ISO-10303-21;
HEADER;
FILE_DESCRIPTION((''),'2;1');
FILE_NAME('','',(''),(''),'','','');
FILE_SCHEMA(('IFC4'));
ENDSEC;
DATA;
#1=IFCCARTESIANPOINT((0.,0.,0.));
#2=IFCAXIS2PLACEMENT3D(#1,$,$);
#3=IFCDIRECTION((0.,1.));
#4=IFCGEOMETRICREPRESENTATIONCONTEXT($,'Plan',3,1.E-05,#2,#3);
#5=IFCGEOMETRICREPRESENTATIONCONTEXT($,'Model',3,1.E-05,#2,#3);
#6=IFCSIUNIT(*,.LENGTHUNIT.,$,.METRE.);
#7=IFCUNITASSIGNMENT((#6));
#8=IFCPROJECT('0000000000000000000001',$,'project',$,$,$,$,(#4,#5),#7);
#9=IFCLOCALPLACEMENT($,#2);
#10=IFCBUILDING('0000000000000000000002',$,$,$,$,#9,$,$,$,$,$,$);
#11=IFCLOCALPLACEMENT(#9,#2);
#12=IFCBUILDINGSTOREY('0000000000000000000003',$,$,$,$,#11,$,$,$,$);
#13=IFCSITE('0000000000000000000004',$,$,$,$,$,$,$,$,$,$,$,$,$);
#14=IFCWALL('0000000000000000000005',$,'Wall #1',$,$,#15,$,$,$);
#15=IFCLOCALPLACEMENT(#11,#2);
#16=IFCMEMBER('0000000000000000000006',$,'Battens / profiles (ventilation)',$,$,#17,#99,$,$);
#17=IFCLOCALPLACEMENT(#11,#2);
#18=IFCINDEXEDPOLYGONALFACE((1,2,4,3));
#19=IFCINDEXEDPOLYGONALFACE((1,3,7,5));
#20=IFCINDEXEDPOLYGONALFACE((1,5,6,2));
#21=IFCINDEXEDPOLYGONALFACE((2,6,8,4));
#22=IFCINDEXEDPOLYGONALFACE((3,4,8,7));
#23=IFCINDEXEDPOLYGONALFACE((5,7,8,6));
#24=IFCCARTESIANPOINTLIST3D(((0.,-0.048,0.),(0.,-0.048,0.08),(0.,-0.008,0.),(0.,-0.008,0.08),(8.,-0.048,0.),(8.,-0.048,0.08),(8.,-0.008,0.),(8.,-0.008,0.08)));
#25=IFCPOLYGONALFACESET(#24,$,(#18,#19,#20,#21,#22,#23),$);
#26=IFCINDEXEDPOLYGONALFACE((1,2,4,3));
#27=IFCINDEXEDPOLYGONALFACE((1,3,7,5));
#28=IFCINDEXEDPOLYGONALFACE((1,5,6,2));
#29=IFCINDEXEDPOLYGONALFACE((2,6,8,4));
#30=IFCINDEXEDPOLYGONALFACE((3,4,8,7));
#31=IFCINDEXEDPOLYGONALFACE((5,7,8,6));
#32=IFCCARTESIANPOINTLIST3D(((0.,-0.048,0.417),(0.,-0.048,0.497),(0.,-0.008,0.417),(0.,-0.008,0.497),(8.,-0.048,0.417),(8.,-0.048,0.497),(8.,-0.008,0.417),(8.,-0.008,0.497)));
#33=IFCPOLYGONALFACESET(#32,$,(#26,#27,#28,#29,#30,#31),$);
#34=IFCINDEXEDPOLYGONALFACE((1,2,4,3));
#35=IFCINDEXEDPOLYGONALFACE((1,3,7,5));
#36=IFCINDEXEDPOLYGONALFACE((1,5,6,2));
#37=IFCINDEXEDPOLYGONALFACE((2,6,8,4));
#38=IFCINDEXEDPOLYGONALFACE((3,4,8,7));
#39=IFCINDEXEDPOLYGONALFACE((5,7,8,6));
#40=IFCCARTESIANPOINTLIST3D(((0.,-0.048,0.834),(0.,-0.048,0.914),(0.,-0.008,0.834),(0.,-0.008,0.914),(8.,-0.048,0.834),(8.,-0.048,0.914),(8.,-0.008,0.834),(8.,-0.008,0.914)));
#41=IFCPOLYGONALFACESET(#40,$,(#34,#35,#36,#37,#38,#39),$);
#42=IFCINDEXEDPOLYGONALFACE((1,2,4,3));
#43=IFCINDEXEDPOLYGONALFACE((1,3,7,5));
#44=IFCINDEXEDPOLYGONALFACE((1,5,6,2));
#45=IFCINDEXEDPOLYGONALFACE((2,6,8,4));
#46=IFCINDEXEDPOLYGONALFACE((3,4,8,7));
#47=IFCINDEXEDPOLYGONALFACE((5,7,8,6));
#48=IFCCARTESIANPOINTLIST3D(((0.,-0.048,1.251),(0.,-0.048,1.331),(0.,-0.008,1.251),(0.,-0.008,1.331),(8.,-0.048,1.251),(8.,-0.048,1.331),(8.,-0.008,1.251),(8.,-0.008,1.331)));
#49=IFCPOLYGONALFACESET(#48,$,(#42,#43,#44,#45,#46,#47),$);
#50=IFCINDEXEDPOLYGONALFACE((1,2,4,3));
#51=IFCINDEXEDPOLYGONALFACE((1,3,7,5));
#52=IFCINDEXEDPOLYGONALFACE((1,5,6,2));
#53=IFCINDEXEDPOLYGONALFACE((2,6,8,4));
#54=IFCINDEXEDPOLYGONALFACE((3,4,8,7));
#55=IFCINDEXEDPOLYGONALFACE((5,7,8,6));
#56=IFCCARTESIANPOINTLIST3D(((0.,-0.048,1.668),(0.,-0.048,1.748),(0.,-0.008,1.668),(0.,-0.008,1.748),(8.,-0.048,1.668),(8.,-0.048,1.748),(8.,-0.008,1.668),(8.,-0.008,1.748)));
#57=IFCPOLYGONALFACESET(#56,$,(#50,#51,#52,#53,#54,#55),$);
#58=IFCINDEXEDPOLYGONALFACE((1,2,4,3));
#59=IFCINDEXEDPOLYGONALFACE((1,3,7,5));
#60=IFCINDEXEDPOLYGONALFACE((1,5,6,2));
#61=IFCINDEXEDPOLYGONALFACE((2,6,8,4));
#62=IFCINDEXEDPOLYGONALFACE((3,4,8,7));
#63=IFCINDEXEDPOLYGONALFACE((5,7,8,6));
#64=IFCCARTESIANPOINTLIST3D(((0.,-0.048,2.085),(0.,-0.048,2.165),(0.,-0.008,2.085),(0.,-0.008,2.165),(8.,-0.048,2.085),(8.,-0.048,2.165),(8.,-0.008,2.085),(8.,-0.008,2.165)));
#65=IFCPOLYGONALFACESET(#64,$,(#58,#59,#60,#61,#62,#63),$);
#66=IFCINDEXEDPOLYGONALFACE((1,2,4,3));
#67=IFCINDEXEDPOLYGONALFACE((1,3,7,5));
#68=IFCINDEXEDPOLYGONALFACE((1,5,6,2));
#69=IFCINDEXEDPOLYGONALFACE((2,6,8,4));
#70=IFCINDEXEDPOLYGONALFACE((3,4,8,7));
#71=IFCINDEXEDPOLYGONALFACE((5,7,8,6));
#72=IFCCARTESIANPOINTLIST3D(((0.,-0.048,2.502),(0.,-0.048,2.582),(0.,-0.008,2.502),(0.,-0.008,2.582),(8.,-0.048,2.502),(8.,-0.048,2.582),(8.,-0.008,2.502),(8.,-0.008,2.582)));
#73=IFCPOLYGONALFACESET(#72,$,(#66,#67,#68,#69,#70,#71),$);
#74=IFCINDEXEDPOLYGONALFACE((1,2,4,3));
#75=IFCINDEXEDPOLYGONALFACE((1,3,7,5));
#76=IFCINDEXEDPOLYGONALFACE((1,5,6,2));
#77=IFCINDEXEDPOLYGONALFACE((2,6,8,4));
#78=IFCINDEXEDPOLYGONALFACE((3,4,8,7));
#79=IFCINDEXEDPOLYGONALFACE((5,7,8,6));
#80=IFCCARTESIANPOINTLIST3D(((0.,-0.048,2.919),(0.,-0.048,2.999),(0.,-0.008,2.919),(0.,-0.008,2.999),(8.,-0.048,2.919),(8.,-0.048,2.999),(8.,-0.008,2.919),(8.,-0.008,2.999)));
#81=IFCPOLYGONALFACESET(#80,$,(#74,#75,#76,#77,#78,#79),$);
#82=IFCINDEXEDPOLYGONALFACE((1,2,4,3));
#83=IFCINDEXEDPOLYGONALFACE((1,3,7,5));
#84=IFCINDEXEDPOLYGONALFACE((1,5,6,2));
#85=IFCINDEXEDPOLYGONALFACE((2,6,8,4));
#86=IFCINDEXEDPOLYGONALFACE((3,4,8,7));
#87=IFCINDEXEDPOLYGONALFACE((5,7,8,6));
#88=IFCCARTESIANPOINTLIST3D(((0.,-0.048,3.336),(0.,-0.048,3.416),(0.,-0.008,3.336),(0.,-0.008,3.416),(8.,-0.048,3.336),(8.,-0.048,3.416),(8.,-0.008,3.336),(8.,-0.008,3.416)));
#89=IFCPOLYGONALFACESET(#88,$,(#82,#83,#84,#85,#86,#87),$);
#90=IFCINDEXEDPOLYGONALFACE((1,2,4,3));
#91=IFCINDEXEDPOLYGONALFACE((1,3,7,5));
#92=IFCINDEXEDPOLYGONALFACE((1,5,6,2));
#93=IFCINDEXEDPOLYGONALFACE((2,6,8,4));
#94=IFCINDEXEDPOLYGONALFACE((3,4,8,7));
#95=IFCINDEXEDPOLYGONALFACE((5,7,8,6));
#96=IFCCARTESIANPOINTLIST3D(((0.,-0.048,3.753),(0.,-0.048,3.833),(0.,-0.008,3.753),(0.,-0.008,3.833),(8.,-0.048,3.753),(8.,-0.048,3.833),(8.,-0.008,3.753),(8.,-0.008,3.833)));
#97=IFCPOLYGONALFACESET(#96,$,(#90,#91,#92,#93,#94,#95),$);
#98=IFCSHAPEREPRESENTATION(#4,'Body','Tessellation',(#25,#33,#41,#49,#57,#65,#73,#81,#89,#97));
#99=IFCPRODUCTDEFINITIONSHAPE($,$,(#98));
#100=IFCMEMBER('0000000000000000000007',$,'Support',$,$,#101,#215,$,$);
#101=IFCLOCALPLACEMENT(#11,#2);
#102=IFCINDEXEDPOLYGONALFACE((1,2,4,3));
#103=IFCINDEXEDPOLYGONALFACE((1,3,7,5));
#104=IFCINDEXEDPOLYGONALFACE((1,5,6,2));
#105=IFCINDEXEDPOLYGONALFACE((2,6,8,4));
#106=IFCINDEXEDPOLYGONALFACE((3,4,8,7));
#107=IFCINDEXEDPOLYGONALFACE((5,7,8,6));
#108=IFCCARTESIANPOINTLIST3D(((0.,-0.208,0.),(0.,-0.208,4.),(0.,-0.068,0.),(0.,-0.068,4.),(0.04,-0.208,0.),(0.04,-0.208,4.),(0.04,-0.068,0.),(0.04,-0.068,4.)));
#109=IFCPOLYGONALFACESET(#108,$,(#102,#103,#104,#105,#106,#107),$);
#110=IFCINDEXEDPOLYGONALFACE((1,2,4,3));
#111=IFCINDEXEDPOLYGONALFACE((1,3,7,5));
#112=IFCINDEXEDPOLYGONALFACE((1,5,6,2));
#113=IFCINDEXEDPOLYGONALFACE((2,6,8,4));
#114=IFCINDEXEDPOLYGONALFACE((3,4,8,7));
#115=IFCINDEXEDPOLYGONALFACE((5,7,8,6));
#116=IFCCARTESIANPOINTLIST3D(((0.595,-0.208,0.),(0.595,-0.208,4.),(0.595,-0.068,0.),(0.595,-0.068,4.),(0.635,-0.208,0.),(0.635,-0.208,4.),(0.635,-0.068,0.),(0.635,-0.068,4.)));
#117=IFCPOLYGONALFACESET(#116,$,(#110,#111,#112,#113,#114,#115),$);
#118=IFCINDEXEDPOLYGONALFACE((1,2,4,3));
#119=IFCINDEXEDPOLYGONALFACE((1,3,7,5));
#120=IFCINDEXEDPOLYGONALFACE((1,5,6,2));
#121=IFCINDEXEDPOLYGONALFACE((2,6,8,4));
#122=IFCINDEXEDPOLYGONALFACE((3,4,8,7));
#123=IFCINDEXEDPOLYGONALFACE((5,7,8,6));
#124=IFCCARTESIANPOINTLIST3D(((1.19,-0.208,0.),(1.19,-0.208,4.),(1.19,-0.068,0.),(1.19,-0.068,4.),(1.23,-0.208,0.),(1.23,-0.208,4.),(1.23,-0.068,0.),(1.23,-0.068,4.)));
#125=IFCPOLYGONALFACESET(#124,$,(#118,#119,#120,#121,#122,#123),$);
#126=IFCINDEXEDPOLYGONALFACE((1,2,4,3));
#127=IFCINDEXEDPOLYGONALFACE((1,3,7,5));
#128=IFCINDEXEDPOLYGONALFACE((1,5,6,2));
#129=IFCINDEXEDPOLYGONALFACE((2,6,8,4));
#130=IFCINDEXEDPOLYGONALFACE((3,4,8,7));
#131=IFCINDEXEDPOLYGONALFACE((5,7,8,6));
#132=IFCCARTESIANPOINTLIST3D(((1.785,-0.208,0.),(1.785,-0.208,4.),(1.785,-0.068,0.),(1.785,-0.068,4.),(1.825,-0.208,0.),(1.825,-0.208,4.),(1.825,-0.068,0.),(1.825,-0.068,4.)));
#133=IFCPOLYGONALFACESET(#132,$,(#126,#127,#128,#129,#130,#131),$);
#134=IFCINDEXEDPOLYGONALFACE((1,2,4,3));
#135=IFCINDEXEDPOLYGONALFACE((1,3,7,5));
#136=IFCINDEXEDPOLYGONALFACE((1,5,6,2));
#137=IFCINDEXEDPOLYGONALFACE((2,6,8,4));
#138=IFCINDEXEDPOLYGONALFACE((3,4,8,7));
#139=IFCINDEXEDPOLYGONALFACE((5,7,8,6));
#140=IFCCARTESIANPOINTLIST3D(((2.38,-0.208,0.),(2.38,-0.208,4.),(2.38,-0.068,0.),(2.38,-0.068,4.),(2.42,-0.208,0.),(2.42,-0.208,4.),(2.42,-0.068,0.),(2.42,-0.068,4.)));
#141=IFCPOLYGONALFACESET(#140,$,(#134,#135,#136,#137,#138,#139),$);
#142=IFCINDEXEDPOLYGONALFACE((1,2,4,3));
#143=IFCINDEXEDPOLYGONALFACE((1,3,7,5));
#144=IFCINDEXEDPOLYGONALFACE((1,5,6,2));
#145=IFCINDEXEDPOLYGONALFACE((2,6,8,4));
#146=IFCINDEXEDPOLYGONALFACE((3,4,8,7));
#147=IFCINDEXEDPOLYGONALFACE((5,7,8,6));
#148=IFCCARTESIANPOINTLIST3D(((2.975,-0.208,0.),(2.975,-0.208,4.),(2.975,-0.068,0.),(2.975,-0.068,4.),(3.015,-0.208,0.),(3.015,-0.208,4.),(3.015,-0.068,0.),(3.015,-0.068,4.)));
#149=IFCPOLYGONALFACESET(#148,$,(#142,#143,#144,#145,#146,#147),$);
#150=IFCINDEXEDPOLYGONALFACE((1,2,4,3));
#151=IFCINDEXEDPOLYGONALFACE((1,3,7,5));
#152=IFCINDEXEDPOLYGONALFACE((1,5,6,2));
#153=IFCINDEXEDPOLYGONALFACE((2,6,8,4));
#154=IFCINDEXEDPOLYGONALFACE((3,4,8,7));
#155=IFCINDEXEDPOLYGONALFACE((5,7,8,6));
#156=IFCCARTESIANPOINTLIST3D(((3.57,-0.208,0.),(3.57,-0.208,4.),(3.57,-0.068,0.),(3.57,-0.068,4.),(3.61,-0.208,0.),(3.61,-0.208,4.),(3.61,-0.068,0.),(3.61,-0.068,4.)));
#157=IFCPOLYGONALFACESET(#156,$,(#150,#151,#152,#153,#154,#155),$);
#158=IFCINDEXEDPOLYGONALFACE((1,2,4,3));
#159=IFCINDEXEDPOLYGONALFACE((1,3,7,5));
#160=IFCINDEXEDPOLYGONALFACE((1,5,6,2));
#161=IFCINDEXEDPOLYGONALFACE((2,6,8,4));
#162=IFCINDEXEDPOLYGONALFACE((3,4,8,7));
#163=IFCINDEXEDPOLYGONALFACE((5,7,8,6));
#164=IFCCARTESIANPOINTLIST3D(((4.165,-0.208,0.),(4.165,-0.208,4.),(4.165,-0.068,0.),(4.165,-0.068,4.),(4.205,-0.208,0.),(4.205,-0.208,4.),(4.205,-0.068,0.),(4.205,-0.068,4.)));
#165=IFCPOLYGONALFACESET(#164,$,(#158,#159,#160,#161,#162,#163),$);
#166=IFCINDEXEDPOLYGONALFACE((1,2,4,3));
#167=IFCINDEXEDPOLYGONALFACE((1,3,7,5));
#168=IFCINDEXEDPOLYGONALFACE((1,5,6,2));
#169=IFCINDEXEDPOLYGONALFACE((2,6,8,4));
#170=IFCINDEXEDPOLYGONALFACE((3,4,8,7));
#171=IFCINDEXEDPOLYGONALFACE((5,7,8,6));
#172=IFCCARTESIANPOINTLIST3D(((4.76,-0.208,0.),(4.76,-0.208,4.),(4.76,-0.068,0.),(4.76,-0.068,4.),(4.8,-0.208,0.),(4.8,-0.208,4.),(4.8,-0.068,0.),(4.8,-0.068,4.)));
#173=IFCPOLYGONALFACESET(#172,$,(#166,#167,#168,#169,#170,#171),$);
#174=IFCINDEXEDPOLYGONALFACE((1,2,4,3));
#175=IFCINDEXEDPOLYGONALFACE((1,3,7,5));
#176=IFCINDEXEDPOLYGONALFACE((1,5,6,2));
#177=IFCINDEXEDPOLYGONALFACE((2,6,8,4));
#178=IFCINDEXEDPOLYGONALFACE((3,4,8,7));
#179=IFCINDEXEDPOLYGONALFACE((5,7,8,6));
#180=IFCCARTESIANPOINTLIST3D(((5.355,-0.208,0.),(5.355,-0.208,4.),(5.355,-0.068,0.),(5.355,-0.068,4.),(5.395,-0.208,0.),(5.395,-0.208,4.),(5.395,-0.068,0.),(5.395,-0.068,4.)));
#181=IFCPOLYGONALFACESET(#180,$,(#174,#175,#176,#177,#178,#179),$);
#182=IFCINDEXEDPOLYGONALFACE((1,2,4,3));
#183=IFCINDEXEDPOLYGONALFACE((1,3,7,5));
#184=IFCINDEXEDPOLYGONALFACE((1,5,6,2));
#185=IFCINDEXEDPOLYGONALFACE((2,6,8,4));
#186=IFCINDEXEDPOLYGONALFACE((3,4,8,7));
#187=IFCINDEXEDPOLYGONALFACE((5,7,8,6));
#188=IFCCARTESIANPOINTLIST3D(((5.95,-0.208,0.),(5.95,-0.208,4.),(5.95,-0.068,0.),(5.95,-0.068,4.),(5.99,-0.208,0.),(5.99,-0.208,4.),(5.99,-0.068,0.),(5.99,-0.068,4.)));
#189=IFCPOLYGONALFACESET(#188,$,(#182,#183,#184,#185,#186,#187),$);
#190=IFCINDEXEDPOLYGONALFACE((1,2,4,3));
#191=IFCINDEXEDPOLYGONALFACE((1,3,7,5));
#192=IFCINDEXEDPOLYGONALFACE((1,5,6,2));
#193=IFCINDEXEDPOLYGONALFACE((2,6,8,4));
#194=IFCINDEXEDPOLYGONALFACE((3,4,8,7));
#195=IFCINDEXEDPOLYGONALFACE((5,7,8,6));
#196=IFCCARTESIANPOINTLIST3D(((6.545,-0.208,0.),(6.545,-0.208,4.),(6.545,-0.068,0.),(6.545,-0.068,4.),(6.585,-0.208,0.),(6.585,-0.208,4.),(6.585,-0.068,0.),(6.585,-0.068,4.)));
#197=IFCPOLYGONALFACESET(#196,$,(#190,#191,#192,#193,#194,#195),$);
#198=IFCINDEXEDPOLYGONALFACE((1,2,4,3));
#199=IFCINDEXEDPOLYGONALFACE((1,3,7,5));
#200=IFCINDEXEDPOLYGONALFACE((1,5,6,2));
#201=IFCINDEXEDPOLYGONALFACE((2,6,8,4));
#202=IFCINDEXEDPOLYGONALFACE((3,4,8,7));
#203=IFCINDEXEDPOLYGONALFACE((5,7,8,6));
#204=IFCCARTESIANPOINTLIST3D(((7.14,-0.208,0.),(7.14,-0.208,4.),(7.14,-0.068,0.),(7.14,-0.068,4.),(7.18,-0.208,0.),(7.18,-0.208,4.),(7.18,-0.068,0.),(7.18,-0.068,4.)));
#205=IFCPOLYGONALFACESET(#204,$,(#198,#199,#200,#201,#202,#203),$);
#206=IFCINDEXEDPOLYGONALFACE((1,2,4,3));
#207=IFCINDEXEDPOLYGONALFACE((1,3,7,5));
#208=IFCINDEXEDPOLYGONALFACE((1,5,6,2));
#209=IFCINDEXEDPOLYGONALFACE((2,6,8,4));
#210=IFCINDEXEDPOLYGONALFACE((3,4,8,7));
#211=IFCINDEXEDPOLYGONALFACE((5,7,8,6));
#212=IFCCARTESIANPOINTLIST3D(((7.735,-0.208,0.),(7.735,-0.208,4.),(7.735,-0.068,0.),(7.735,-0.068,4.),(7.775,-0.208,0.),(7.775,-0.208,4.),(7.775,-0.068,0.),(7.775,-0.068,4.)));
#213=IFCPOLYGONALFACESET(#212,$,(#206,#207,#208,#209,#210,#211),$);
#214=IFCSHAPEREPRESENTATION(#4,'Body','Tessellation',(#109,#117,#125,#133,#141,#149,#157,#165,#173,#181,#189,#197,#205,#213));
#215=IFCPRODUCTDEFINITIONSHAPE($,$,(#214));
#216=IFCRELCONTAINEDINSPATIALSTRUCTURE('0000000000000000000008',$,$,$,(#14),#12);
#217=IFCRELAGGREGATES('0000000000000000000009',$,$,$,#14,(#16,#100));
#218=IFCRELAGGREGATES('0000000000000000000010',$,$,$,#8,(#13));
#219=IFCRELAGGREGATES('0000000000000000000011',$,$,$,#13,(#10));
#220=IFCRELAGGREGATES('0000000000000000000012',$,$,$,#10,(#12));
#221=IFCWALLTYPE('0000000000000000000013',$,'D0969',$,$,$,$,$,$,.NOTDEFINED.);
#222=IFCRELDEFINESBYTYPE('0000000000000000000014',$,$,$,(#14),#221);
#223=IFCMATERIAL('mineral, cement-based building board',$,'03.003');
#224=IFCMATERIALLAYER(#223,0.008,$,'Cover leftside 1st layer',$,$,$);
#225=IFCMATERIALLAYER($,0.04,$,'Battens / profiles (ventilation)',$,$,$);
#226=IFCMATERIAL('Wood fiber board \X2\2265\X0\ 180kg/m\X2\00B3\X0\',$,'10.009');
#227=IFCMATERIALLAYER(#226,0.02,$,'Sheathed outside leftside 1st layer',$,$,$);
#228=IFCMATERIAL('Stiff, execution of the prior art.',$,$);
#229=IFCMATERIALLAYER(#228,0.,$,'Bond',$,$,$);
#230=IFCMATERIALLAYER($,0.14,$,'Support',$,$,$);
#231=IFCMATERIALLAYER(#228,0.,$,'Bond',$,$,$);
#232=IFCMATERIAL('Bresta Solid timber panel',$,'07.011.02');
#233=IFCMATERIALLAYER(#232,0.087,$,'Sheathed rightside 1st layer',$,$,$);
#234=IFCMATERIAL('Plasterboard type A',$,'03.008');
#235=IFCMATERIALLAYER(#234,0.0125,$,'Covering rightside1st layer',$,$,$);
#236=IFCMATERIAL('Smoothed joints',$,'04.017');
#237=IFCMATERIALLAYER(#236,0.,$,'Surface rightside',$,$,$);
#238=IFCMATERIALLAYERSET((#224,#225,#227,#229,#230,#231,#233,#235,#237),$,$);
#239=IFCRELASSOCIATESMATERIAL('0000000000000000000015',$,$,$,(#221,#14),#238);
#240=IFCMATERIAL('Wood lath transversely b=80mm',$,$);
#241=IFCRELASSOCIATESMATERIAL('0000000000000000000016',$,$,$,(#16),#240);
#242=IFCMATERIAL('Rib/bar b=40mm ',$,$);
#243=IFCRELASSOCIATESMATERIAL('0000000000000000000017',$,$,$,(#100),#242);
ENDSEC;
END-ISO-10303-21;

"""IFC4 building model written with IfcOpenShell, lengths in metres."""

from ifc_helpers import new_model, si_unit, direction, frame, frame_2d, origin, place, context, project, spatial, rectangle, extrude, material, layer, layer_set, type_object, element, aggregate, save


model = new_model("IFC4")

# Units and contexts
plan_context = context("Plan", 3, precision=1e-05, world=origin(), true_north=direction((0.0, 1.0)))
model_context = context("Model", 3, precision=1e-05, world=origin(), true_north=direction((0.0, 1.0)))
ifc_project = project(units=[si_unit("LENGTHUNIT", "METRE")], contexts=[plan_context, model_context])

# Site, building, storey
site = spatial("IfcSite", under=ifc_project)
building_placement = place(None, origin())
building = spatial("IfcBuilding", under=site, at=building_placement)
storey_placement = place(building_placement, origin())
storey = spatial("IfcBuildingStorey", under=building, at=storey_placement)

# Wall, members
ifc_material_1 = material(Name="mineral, cement-based building board", Category="03.003")
ifc_layer_1 = layer(ifc_material_1, 0.008, Name="Cover leftside 1st layer")
ifc_layer_2 = layer(None, 0.04, Name="Battens / profiles (ventilation)")
ifc_material_2 = material(Name="Wood fiber board ≥ 180kg/m³", Category="10.009")
ifc_layer_3 = layer(ifc_material_2, 0.02, Name="Sheathed outside leftside 1st layer")
ifc_material_3 = material(Name="Stiff, execution of the prior art.")
ifc_layer_4 = layer(ifc_material_3, 0.0, Name="Bond")
ifc_layer_5 = layer(None, 0.14, Name="Support")
ifc_layer_6 = layer(ifc_material_3, 0.0, Name="Bond")
ifc_material_4 = material(Name="Bresta Solid timber panel", Category="07.011.02")
ifc_layer_7 = layer(ifc_material_4, 0.087, Name="Sheathed rightside 1st layer")
ifc_material_5 = material(Name="Plasterboard type A", Category="03.008")
ifc_layer_8 = layer(ifc_material_5, 0.0125, Name="Covering rightside1st layer")
ifc_material_6 = material(Name="Smoothed joints", Category="04.017")
ifc_layer_9 = layer(ifc_material_6, 0.0, Name="Surface rightside")
ifc_layer_set = layer_set([ifc_layer_1, ifc_layer_2, ifc_layer_3, ifc_layer_4, ifc_layer_5, ifc_layer_6, ifc_layer_7, ifc_layer_8, ifc_layer_9])
wall_type = type_object("IfcWallType", Name="D0969", PredefinedType="NOTDEFINED", material=ifc_layer_set)
wall_placement = place(None, frame((0.0, 0.0, 0.0), z_axis=(0.0, -1.0, 0.0), x_axis=(1.0, 0.0, 0.0)))
wall = element("IfcWall", 1, at=wall_placement, inside=storey, type_object=wall_type, material=ifc_layer_set, Name="Wall #1")
ifc_material_7 = material(Name="Wood lath transversely b=80mm")
member_1_placement = place(wall_placement, origin())
member_1 = element("IfcMember", 2, at=member_1_placement, material=ifc_material_7, Name="Battens / profiles (ventilation)", context=plan_context, shape_type="SweptSolid", body=[
    extrude(rectangle(XDim=0.08, YDim=0.04, at=frame_2d((0.04, 0.02), x_axis=(1.0, 0.0))), frame((0.0, 0.0, 0.008), z_axis=(1.0, 0.0, 0.0), x_axis=(0.0, 1.0, 0.0)), (0.0, 0.0, 1.0), 8.0),
    extrude(rectangle(XDim=0.08, YDim=0.04, at=frame_2d((0.04, 0.02), x_axis=(1.0, 0.0))), frame((0.0, 0.417, 0.008), z_axis=(1.0, 0.0, 0.0), x_axis=(0.0, 1.0, 0.0)), (0.0, 0.0, 1.0), 8.0),
    extrude(rectangle(XDim=0.08, YDim=0.04, at=frame_2d((0.04, 0.02), x_axis=(1.0, 0.0))), frame((0.0, 0.834, 0.008), z_axis=(1.0, 0.0, 0.0), x_axis=(0.0, 1.0, 0.0)), (0.0, 0.0, 1.0), 8.0),
    extrude(rectangle(XDim=0.08, YDim=0.04, at=frame_2d((0.04, 0.02), x_axis=(1.0, 0.0))), frame((0.0, 1.251, 0.008), z_axis=(1.0, 0.0, 0.0), x_axis=(0.0, 1.0, 0.0)), (0.0, 0.0, 1.0), 8.0),
    extrude(rectangle(XDim=0.08, YDim=0.04, at=frame_2d((0.04, 0.02), x_axis=(1.0, 0.0))), frame((0.0, 1.668, 0.008), z_axis=(1.0, 0.0, 0.0), x_axis=(0.0, 1.0, 0.0)), (0.0, 0.0, 1.0), 8.0),
    extrude(rectangle(XDim=0.08, YDim=0.04, at=frame_2d((0.04, 0.02), x_axis=(1.0, 0.0))), frame((0.0, 2.085, 0.008), z_axis=(1.0, 0.0, 0.0), x_axis=(0.0, 1.0, 0.0)), (0.0, 0.0, 1.0), 8.0),
    extrude(rectangle(XDim=0.08, YDim=0.04, at=frame_2d((0.04, 0.02), x_axis=(1.0, 0.0))), frame((0.0, 2.502, 0.008), z_axis=(1.0, 0.0, 0.0), x_axis=(0.0, 1.0, 0.0)), (0.0, 0.0, 1.0), 8.0),
    extrude(rectangle(XDim=0.08, YDim=0.04, at=frame_2d((0.04, 0.02), x_axis=(1.0, 0.0))), frame((0.0, 2.919, 0.008), z_axis=(1.0, 0.0, 0.0), x_axis=(0.0, 1.0, 0.0)), (0.0, 0.0, 1.0), 8.0),
    extrude(rectangle(XDim=0.08, YDim=0.04, at=frame_2d((0.04, 0.02), x_axis=(1.0, 0.0))), frame((0.0, 3.336, 0.008), z_axis=(1.0, 0.0, 0.0), x_axis=(0.0, 1.0, 0.0)), (0.0, 0.0, 1.0), 8.0),
    extrude(rectangle(XDim=0.08, YDim=0.04, at=frame_2d((0.04, 0.02), x_axis=(1.0, 0.0))), frame((0.0, 3.753, 0.008), z_axis=(1.0, 0.0, 0.0), x_axis=(0.0, 1.0, 0.0)), (0.0, 0.0, 1.0), 8.0),
])
ifc_material_8 = material(Name="Rib/bar b=40mm ")
member_2_placement = place(wall_placement, origin())
member_2 = element("IfcMember", 3, at=member_2_placement, material=ifc_material_8, Name="Support", context=plan_context, shape_type="SweptSolid", body=[
    extrude(rectangle(XDim=0.04, YDim=0.14, at=frame_2d((0.02, 0.07), x_axis=(1.0, 0.0))), frame((0.0, 4.0, 0.068), z_axis=(0.0, -1.0, 0.0), x_axis=(1.0, 0.0, 0.0)), (0.0, 0.0, 1.0), 4.0),
    extrude(rectangle(XDim=0.04, YDim=0.14, at=frame_2d((0.02, 0.07), x_axis=(1.0, 0.0))), frame((0.595, 4.0, 0.068), z_axis=(0.0, -1.0, 0.0), x_axis=(1.0, 0.0, 0.0)), (0.0, 0.0, 1.0), 4.0),
    extrude(rectangle(XDim=0.04, YDim=0.14, at=frame_2d((0.02, 0.07), x_axis=(1.0, 0.0))), frame((1.19, 4.0, 0.068), z_axis=(0.0, -1.0, 0.0), x_axis=(1.0, 0.0, 0.0)), (0.0, 0.0, 1.0), 4.0),
    extrude(rectangle(XDim=0.04, YDim=0.14, at=frame_2d((0.02, 0.07), x_axis=(1.0, 0.0))), frame((1.785, 4.0, 0.068), z_axis=(0.0, -1.0, 0.0), x_axis=(1.0, 0.0, 0.0)), (0.0, 0.0, 1.0), 4.0),
    extrude(rectangle(XDim=0.04, YDim=0.14, at=frame_2d((0.02, 0.07), x_axis=(1.0, 0.0))), frame((2.38, 4.0, 0.068), z_axis=(0.0, -1.0, 0.0), x_axis=(1.0, 0.0, 0.0)), (0.0, 0.0, 1.0), 4.0),
    extrude(rectangle(XDim=0.04, YDim=0.14, at=frame_2d((0.02, 0.07), x_axis=(1.0, 0.0))), frame((2.975, 4.0, 0.068), z_axis=(0.0, -1.0, 0.0), x_axis=(1.0, 0.0, 0.0)), (0.0, 0.0, 1.0), 4.0),
    extrude(rectangle(XDim=0.04, YDim=0.14, at=frame_2d((0.02, 0.07), x_axis=(1.0, 0.0))), frame((3.57, 4.0, 0.068), z_axis=(0.0, -1.0, 0.0), x_axis=(1.0, 0.0, 0.0)), (0.0, 0.0, 1.0), 4.0),
    extrude(rectangle(XDim=0.04, YDim=0.14, at=frame_2d((0.02, 0.07), x_axis=(1.0, 0.0))), frame((4.165, 4.0, 0.068), z_axis=(0.0, -1.0, 0.0), x_axis=(1.0, 0.0, 0.0)), (0.0, 0.0, 1.0), 4.0),
    extrude(rectangle(XDim=0.04, YDim=0.14, at=frame_2d((0.02, 0.07), x_axis=(1.0, 0.0))), frame((4.76, 4.0, 0.068), z_axis=(0.0, -1.0, 0.0), x_axis=(1.0, 0.0, 0.0)), (0.0, 0.0, 1.0), 4.0),
    extrude(rectangle(XDim=0.04, YDim=0.14, at=frame_2d((0.02, 0.07), x_axis=(1.0, 0.0))), frame((5.355, 4.0, 0.068), z_axis=(0.0, -1.0, 0.0), x_axis=(1.0, 0.0, 0.0)), (0.0, 0.0, 1.0), 4.0),
    extrude(rectangle(XDim=0.04, YDim=0.14, at=frame_2d((0.02, 0.07), x_axis=(1.0, 0.0))), frame((5.95, 4.0, 0.068), z_axis=(0.0, -1.0, 0.0), x_axis=(1.0, 0.0, 0.0)), (0.0, 0.0, 1.0), 4.0),
    extrude(rectangle(XDim=0.04, YDim=0.14, at=frame_2d((0.02, 0.07), x_axis=(1.0, 0.0))), frame((6.545, 4.0, 0.068), z_axis=(0.0, -1.0, 0.0), x_axis=(1.0, 0.0, 0.0)), (0.0, 0.0, 1.0), 4.0),
    extrude(rectangle(XDim=0.04, YDim=0.14, at=frame_2d((0.02, 0.07), x_axis=(1.0, 0.0))), frame((7.14, 4.0, 0.068), z_axis=(0.0, -1.0, 0.0), x_axis=(1.0, 0.0, 0.0)), (0.0, 0.0, 1.0), 4.0),
    extrude(rectangle(XDim=0.04, YDim=0.14, at=frame_2d((0.02, 0.07), x_axis=(1.0, 0.0))), frame((7.735, 4.0, 0.068), z_axis=(0.0, -1.0, 0.0), x_axis=(1.0, 0.0, 0.0)), (0.0, 0.0, 1.0), 4.0),
])
aggregate(wall, [member_1, member_2])

save(model, "model.ifc")
